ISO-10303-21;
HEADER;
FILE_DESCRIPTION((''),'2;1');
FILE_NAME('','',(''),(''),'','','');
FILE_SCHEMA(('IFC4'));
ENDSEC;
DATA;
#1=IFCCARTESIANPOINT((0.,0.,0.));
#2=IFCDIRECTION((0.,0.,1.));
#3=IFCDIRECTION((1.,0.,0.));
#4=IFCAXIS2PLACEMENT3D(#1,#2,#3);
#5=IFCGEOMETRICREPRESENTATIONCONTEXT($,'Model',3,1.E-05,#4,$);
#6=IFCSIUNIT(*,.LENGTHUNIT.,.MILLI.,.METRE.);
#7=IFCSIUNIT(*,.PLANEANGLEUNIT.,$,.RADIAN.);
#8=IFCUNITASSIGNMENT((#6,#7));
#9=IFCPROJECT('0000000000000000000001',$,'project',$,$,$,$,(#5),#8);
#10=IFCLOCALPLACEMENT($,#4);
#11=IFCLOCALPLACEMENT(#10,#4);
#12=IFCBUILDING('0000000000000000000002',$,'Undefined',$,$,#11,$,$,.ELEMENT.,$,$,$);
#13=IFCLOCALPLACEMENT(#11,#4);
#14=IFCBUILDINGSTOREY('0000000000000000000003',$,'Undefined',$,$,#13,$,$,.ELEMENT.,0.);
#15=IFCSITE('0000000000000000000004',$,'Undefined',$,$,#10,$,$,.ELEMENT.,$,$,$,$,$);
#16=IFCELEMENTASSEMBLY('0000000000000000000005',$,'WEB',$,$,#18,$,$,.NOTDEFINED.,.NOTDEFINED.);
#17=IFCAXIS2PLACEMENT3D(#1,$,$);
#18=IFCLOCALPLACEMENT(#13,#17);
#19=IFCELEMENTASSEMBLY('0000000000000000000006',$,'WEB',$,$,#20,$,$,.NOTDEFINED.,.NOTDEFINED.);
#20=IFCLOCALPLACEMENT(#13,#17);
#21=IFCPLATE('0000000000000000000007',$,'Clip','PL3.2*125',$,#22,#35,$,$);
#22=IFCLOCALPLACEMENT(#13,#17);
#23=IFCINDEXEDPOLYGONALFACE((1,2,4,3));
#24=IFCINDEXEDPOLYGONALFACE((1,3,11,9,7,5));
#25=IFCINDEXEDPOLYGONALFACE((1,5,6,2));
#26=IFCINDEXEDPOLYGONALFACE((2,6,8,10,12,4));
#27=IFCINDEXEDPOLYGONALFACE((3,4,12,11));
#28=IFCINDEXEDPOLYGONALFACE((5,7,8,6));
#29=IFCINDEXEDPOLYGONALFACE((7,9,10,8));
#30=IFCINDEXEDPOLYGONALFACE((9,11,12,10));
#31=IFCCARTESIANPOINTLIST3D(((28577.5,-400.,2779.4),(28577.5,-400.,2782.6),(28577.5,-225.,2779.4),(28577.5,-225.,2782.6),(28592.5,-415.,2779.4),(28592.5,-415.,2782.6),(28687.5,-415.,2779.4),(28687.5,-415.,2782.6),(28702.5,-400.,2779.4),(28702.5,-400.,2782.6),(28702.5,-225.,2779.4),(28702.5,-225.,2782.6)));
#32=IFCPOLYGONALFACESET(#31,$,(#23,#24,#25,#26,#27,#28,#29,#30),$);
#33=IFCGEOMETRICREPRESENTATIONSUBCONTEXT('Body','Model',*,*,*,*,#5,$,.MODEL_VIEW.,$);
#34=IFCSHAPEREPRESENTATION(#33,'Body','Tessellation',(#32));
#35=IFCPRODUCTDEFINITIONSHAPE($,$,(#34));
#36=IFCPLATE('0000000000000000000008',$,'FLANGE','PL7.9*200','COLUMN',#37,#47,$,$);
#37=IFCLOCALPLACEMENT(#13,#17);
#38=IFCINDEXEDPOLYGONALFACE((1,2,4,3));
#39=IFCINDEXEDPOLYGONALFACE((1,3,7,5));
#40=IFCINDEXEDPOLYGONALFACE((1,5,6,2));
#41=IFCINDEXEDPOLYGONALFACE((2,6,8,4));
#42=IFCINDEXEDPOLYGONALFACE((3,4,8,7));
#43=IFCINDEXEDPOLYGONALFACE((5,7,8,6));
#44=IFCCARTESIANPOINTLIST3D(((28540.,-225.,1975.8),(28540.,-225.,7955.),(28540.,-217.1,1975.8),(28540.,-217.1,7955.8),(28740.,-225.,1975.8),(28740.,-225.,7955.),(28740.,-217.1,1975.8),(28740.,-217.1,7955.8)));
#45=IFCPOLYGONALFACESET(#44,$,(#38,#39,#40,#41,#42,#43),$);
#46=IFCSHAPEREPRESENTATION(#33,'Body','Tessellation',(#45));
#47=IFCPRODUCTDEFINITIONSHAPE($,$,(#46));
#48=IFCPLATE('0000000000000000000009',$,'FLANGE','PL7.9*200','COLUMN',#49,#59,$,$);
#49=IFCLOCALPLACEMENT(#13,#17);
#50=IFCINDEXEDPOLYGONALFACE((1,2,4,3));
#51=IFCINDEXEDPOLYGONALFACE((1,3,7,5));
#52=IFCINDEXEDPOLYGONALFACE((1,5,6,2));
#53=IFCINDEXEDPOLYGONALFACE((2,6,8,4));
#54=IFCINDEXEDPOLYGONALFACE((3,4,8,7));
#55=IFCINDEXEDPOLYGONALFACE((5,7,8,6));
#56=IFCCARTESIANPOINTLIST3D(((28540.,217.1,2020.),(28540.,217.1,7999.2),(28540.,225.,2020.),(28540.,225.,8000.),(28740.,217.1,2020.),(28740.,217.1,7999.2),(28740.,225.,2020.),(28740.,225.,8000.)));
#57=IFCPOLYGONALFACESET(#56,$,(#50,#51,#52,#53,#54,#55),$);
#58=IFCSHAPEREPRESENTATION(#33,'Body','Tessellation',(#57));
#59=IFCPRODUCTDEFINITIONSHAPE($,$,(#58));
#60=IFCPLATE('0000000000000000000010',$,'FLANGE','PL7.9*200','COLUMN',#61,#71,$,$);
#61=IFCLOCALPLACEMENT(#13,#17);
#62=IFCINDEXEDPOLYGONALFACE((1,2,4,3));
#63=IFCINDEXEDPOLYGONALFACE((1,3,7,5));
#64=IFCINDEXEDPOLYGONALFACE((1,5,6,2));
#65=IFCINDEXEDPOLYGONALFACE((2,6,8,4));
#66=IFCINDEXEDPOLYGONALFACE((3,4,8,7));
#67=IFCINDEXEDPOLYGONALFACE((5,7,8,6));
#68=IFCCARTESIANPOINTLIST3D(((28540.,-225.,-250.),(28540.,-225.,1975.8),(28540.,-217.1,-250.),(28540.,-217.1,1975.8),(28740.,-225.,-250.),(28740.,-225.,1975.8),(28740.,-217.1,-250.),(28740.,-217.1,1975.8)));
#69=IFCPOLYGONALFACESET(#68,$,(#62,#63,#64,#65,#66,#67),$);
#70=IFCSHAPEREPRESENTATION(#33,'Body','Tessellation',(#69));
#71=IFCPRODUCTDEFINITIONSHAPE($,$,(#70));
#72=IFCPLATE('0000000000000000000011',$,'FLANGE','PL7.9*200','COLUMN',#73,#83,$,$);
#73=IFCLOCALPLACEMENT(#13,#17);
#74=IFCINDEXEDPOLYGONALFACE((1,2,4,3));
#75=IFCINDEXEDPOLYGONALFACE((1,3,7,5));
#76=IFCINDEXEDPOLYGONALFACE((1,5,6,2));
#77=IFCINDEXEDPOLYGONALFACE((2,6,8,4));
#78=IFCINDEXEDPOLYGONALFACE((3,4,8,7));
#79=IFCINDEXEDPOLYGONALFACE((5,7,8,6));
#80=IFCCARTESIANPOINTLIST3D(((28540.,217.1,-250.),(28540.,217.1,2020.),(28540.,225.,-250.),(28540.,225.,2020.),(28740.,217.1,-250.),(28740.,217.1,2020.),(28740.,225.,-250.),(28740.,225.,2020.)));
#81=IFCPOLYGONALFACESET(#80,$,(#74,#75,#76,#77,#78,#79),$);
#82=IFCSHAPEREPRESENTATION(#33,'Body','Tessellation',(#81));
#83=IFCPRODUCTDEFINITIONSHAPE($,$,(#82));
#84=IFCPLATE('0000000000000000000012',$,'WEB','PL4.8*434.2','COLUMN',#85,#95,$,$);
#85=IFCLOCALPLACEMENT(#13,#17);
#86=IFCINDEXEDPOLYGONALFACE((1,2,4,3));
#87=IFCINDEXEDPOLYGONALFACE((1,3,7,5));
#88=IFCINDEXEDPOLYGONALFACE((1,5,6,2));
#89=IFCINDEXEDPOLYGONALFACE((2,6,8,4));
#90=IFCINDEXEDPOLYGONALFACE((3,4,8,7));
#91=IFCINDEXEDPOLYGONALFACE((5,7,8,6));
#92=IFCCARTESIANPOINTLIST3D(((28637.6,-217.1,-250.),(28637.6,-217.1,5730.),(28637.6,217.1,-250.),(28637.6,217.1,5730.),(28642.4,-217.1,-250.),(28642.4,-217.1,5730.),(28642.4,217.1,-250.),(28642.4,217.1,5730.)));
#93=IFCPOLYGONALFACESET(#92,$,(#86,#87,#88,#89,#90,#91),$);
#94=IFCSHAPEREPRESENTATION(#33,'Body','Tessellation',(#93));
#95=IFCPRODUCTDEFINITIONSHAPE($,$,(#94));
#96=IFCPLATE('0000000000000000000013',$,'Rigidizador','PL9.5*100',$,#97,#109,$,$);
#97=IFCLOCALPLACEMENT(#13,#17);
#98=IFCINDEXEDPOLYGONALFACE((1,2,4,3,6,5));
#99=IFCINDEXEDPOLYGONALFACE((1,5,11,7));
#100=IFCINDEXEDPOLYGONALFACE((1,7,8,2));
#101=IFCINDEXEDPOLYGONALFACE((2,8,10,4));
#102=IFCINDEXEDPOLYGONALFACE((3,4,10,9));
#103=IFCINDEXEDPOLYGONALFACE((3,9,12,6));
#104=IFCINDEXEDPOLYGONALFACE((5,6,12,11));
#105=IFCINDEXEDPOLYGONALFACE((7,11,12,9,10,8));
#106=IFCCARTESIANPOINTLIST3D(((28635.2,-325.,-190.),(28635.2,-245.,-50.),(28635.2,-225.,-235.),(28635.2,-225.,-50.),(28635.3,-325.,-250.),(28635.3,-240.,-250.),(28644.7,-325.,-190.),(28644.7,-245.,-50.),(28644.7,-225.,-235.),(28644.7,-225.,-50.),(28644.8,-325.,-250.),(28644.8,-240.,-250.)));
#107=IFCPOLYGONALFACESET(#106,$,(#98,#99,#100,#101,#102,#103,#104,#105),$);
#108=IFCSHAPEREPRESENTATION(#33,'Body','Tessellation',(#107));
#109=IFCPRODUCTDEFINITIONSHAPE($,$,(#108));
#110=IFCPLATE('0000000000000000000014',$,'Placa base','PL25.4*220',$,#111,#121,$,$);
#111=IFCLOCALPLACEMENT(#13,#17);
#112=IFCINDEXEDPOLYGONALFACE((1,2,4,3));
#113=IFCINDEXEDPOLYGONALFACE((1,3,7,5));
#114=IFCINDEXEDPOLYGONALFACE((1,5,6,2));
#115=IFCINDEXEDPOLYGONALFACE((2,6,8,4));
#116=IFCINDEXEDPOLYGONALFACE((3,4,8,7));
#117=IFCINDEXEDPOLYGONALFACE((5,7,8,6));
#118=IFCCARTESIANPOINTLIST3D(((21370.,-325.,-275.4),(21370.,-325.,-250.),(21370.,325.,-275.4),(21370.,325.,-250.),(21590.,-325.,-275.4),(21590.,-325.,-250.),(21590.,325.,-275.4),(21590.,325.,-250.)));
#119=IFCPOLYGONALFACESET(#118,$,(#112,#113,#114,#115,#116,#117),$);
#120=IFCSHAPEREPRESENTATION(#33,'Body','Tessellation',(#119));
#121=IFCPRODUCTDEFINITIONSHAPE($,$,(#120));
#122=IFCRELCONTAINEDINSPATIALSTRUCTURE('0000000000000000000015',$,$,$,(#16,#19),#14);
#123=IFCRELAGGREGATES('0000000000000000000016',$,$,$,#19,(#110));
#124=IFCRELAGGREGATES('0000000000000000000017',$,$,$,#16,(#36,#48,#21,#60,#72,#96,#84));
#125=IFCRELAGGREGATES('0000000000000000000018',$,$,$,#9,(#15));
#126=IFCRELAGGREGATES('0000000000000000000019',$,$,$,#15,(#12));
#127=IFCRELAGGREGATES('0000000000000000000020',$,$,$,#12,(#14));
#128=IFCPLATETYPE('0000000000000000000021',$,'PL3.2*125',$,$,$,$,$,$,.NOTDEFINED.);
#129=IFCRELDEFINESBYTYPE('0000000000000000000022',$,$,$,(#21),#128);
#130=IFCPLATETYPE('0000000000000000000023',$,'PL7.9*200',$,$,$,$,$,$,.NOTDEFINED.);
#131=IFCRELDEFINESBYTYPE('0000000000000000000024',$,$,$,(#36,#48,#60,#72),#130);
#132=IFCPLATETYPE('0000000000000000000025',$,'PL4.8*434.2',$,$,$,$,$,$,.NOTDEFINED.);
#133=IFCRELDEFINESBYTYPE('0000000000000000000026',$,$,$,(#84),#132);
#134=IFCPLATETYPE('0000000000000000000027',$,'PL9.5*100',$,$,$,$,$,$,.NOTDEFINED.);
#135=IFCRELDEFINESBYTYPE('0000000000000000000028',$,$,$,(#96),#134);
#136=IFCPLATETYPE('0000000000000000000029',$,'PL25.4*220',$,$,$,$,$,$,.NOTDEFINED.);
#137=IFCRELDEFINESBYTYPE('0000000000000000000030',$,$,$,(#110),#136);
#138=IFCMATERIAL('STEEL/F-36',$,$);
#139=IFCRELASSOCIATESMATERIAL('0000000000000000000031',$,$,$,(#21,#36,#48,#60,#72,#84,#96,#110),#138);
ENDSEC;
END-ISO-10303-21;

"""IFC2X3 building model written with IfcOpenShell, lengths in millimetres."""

from ifc_helpers import new_model, si_unit, frame, origin_with_axes, place, context, subcontext, project, spatial, polyline, outline, extrude, clip, halfspace, material, type_object, element, aggregate, save


model = new_model("IFC2X3")

# Units and contexts
model_context = context("Model", 3, precision=1e-05, world=origin_with_axes())
body_context = subcontext(model_context, "Body", "Model", "MODEL_VIEW")
ifc_project = project(units=[si_unit("LENGTHUNIT", "METRE", prefix="MILLI"), si_unit("PLANEANGLEUNIT", "RADIAN")], contexts=[model_context])

# Site, building, storey
site_placement = place(None, origin_with_axes())
site = spatial("IfcSite", under=ifc_project, at=site_placement, Name="Undefined", CompositionType="ELEMENT")
building_placement = place(site_placement, origin_with_axes())
building = spatial("IfcBuilding", under=site, at=building_placement, Name="Undefined", CompositionType="ELEMENT")
storey_placement = place(building_placement, origin_with_axes())
storey = spatial("IfcBuildingStorey", under=building, at=storey_placement, Name="Undefined", CompositionType="ELEMENT", Elevation=0.0)

# Element assembly
assembly_1_placement = place(storey_placement, origin_with_axes())
assembly_1 = element("IfcElementAssembly", 1, at=assembly_1_placement, inside=storey, Name="WEB", AssemblyPlace="NOTDEFINED", PredefinedType="NOTDEFINED")
ifc_material_1 = material(Name="STEEL/F-36")

# Element assembly
assembly_2_placement = place(storey_placement, origin_with_axes())
assembly_2 = element("IfcElementAssembly", 2, at=assembly_2_placement, inside=storey, Name="WEB", AssemblyPlace="NOTDEFINED", PredefinedType="NOTDEFINED")
plate_type_1 = type_object("IfcPlateType", Name="PL3.2*125", PredefinedType="NOTDEFINED")

# Plates
plate_1_placement = place(assembly_1_placement, frame((28577.5, -225.0, 2781.0), z_axis=(0.0, 0.000007, -1.0), x_axis=(1.0, 0.0, 0.0)))
plate_1 = element("IfcPlate", 3, at=plate_1_placement, type_object=plate_type_1, material=ifc_material_1, Name="Clip", Description="PL3.2*125", context=body_context, shape_type="SweptSolid", body=[
    extrude(outline(polyline([(0.0, 0.0), (125.0, 0.0), (125.0, 175.0), (110.0, 190.0), (15.0, 190.0), (0.0, 175.0), (0.0, 0.0)])), frame((0.0, 0.0, -1.6), z_axis=(0.0, 0.0, 1.0), x_axis=(1.0, 0.0, 0.0)), (0.0, 0.0, 1.0), 3.2),
])
plate_type_2 = type_object("IfcPlateType", Name="PL7.9*200", PredefinedType="NOTDEFINED")
plate_2_placement = place(assembly_1_placement, frame((28640.0, -221.1, 1975.8), z_axis=(0.0, -1.0, 0.0), x_axis=(0.0, 0.0, 1.0)))
plate_2 = element("IfcPlate", 4, at=plate_2_placement, type_object=plate_type_2, material=ifc_material_1, Name="FLANGE", Description="PL7.9*200", ObjectType="COLUMN", context=body_context, shape_type="Clipping", body=[
    clip(extrude(outline(polyline([(0.0, -100.0), (0.0, 100.0), (5980.0, 100.0), (5980.0, -100.0), (0.0, -100.0)])), frame((0.0, 0.0, -4.0), z_axis=(0.0, 0.0, 1.0), x_axis=(1.0, 0.0, 0.0)), (0.0, 0.0, 1.0), 7.9), halfspace(frame((5979.6, 0.0, 0.0), z_axis=(-0.995037, 0.0, -0.099504), x_axis=(0.0, 1.0, 0.0)), True)),
])
plate_3_placement = place(assembly_1_placement, frame((28640.0, 221.0, 2020.0), z_axis=(0.0, -1.0, 0.0), x_axis=(0.0, 0.0, 1.0)))
plate_3 = element("IfcPlate", 5, at=plate_3_placement, type_object=plate_type_2, material=ifc_material_1, Name="FLANGE", Description="PL7.9*200", ObjectType="COLUMN", context=body_context, shape_type="Clipping", body=[
    clip(extrude(outline(polyline([(0.0, -100.0), (0.0, 100.0), (5980.0, 100.0), (5980.0, -100.0), (0.0, -100.0)])), frame((0.0, 0.0, -4.0), z_axis=(0.0, 0.0, 1.0), x_axis=(1.0, 0.0, 0.0)), (0.0, 0.0, 1.0), 7.9), halfspace(frame((5979.6, 0.0, 0.0), z_axis=(-0.995037, 0.0, -0.099504), x_axis=(0.0, -1.0, 0.0)), True)),
])
plate_4_placement = place(assembly_1_placement, frame((28640.0, -221.1, -250.0), z_axis=(0.0, -1.0, 0.0), x_axis=(0.0, 0.0, 1.0)))
plate_4 = element("IfcPlate", 6, at=plate_4_placement, type_object=plate_type_2, material=ifc_material_1, Name="FLANGE", Description="PL7.9*200", ObjectType="COLUMN", context=body_context, shape_type="SweptSolid", body=[
    extrude(outline(polyline([(0.0, -100.0), (0.0, 100.0), (2225.8, 100.0), (2225.8, -100.0), (0.0, -100.0)])), frame((0.0, 0.0, -4.0), z_axis=(0.0, 0.0, 1.0), x_axis=(1.0, 0.0, 0.0)), (0.0, 0.0, 1.0), 7.9),
])
plate_5_placement = place(assembly_1_placement, frame((28640.0, 221.0, -250.0), z_axis=(0.0, -1.0, 0.0), x_axis=(0.0, 0.0, 1.0)))
plate_5 = element("IfcPlate", 7, at=plate_5_placement, type_object=plate_type_2, material=ifc_material_1, Name="FLANGE", Description="PL7.9*200", ObjectType="COLUMN", context=body_context, shape_type="SweptSolid", body=[
    extrude(outline(polyline([(0.0, -100.0), (0.0, 100.0), (2270.0, 100.0), (2270.0, -100.0), (0.0, -100.0)])), frame((0.0, 0.0, -4.0), z_axis=(0.0, 0.0, 1.0), x_axis=(1.0, 0.0, 0.0)), (0.0, 0.0, 1.0), 7.9),
])
plate_type_3 = type_object("IfcPlateType", Name="PL4.8*434.2", PredefinedType="NOTDEFINED")
plate_6_placement = place(assembly_1_placement, frame((28640.0, 0.0, -250.0), z_axis=(1.0, 0.0, 0.0), x_axis=(0.0, 0.0, 1.0)))
plate_6 = element("IfcPlate", 8, at=plate_6_placement, type_object=plate_type_3, material=ifc_material_1, Name="WEB", Description="PL4.8*434.2", ObjectType="COLUMN", context=body_context, shape_type="SweptSolid", body=[
    extrude(outline(polyline([(0.0, -217.1), (0.0, 217.1), (5980.0, 217.1), (5980.0, -217.1), (0.0, -217.1)])), frame((0.0, 0.0, -2.4), z_axis=(0.0, 0.0, 1.0), x_axis=(1.0, 0.0, 0.0)), (0.0, 0.0, 1.0), 4.8),
])
plate_type_4 = type_object("IfcPlateType", Name="PL9.5*100", PredefinedType="NOTDEFINED")
plate_7_placement = place(assembly_1_placement, frame((28640.0, -225.0, -250.0), z_axis=(-1.0, 0.0, 0.0), x_axis=(0.0, -1.0, 0.0)))
plate_7 = element("IfcPlate", 9, at=plate_7_placement, type_object=plate_type_4, material=ifc_material_1, Name="Rigidizador", Description="PL9.5*100", context=body_context, shape_type="SweptSolid", body=[
    extrude(outline(polyline([(0.0, 15.0), (15.0, 0.0), (100.0, 0.0), (100.0, 60.0), (20.0, 200.0), (0.0, 200.0), (0.0, 15.0)])), frame((0.0, 0.0, -4.7), z_axis=(0.0, 0.0, 1.0), x_axis=(1.0, 0.0, 0.0)), (0.0, 0.0, 1.0), 9.5),
])
plate_type_5 = type_object("IfcPlateType", Name="PL25.4*220", PredefinedType="NOTDEFINED")
plate_8_placement = place(assembly_2_placement, frame((21590.0, 325.0, -262.7), z_axis=(0.0, 0.0, 1.0), x_axis=(-1.0, 0.0, 0.0)))
plate_8 = element("IfcPlate", 10, at=plate_8_placement, type_object=plate_type_5, material=ifc_material_1, Name="Placa base", Description="PL25.4*220", context=body_context, shape_type="SweptSolid", body=[
    extrude(outline(polyline([(0.0, 0.0), (220.0, 0.0), (220.0, 650.0), (0.0, 650.0), (0.0, 0.0)])), frame((0.0, 0.0, -12.7), z_axis=(0.0, 0.0, 1.0), x_axis=(1.0, 0.0, 0.0)), (0.0, 0.0, 1.0), 25.4),
])

aggregate(assembly_2, [plate_8])

aggregate(assembly_1, [plate_2, plate_3, plate_1, plate_4, plate_5, plate_7, plate_6])

save(model, "model.ifc")
